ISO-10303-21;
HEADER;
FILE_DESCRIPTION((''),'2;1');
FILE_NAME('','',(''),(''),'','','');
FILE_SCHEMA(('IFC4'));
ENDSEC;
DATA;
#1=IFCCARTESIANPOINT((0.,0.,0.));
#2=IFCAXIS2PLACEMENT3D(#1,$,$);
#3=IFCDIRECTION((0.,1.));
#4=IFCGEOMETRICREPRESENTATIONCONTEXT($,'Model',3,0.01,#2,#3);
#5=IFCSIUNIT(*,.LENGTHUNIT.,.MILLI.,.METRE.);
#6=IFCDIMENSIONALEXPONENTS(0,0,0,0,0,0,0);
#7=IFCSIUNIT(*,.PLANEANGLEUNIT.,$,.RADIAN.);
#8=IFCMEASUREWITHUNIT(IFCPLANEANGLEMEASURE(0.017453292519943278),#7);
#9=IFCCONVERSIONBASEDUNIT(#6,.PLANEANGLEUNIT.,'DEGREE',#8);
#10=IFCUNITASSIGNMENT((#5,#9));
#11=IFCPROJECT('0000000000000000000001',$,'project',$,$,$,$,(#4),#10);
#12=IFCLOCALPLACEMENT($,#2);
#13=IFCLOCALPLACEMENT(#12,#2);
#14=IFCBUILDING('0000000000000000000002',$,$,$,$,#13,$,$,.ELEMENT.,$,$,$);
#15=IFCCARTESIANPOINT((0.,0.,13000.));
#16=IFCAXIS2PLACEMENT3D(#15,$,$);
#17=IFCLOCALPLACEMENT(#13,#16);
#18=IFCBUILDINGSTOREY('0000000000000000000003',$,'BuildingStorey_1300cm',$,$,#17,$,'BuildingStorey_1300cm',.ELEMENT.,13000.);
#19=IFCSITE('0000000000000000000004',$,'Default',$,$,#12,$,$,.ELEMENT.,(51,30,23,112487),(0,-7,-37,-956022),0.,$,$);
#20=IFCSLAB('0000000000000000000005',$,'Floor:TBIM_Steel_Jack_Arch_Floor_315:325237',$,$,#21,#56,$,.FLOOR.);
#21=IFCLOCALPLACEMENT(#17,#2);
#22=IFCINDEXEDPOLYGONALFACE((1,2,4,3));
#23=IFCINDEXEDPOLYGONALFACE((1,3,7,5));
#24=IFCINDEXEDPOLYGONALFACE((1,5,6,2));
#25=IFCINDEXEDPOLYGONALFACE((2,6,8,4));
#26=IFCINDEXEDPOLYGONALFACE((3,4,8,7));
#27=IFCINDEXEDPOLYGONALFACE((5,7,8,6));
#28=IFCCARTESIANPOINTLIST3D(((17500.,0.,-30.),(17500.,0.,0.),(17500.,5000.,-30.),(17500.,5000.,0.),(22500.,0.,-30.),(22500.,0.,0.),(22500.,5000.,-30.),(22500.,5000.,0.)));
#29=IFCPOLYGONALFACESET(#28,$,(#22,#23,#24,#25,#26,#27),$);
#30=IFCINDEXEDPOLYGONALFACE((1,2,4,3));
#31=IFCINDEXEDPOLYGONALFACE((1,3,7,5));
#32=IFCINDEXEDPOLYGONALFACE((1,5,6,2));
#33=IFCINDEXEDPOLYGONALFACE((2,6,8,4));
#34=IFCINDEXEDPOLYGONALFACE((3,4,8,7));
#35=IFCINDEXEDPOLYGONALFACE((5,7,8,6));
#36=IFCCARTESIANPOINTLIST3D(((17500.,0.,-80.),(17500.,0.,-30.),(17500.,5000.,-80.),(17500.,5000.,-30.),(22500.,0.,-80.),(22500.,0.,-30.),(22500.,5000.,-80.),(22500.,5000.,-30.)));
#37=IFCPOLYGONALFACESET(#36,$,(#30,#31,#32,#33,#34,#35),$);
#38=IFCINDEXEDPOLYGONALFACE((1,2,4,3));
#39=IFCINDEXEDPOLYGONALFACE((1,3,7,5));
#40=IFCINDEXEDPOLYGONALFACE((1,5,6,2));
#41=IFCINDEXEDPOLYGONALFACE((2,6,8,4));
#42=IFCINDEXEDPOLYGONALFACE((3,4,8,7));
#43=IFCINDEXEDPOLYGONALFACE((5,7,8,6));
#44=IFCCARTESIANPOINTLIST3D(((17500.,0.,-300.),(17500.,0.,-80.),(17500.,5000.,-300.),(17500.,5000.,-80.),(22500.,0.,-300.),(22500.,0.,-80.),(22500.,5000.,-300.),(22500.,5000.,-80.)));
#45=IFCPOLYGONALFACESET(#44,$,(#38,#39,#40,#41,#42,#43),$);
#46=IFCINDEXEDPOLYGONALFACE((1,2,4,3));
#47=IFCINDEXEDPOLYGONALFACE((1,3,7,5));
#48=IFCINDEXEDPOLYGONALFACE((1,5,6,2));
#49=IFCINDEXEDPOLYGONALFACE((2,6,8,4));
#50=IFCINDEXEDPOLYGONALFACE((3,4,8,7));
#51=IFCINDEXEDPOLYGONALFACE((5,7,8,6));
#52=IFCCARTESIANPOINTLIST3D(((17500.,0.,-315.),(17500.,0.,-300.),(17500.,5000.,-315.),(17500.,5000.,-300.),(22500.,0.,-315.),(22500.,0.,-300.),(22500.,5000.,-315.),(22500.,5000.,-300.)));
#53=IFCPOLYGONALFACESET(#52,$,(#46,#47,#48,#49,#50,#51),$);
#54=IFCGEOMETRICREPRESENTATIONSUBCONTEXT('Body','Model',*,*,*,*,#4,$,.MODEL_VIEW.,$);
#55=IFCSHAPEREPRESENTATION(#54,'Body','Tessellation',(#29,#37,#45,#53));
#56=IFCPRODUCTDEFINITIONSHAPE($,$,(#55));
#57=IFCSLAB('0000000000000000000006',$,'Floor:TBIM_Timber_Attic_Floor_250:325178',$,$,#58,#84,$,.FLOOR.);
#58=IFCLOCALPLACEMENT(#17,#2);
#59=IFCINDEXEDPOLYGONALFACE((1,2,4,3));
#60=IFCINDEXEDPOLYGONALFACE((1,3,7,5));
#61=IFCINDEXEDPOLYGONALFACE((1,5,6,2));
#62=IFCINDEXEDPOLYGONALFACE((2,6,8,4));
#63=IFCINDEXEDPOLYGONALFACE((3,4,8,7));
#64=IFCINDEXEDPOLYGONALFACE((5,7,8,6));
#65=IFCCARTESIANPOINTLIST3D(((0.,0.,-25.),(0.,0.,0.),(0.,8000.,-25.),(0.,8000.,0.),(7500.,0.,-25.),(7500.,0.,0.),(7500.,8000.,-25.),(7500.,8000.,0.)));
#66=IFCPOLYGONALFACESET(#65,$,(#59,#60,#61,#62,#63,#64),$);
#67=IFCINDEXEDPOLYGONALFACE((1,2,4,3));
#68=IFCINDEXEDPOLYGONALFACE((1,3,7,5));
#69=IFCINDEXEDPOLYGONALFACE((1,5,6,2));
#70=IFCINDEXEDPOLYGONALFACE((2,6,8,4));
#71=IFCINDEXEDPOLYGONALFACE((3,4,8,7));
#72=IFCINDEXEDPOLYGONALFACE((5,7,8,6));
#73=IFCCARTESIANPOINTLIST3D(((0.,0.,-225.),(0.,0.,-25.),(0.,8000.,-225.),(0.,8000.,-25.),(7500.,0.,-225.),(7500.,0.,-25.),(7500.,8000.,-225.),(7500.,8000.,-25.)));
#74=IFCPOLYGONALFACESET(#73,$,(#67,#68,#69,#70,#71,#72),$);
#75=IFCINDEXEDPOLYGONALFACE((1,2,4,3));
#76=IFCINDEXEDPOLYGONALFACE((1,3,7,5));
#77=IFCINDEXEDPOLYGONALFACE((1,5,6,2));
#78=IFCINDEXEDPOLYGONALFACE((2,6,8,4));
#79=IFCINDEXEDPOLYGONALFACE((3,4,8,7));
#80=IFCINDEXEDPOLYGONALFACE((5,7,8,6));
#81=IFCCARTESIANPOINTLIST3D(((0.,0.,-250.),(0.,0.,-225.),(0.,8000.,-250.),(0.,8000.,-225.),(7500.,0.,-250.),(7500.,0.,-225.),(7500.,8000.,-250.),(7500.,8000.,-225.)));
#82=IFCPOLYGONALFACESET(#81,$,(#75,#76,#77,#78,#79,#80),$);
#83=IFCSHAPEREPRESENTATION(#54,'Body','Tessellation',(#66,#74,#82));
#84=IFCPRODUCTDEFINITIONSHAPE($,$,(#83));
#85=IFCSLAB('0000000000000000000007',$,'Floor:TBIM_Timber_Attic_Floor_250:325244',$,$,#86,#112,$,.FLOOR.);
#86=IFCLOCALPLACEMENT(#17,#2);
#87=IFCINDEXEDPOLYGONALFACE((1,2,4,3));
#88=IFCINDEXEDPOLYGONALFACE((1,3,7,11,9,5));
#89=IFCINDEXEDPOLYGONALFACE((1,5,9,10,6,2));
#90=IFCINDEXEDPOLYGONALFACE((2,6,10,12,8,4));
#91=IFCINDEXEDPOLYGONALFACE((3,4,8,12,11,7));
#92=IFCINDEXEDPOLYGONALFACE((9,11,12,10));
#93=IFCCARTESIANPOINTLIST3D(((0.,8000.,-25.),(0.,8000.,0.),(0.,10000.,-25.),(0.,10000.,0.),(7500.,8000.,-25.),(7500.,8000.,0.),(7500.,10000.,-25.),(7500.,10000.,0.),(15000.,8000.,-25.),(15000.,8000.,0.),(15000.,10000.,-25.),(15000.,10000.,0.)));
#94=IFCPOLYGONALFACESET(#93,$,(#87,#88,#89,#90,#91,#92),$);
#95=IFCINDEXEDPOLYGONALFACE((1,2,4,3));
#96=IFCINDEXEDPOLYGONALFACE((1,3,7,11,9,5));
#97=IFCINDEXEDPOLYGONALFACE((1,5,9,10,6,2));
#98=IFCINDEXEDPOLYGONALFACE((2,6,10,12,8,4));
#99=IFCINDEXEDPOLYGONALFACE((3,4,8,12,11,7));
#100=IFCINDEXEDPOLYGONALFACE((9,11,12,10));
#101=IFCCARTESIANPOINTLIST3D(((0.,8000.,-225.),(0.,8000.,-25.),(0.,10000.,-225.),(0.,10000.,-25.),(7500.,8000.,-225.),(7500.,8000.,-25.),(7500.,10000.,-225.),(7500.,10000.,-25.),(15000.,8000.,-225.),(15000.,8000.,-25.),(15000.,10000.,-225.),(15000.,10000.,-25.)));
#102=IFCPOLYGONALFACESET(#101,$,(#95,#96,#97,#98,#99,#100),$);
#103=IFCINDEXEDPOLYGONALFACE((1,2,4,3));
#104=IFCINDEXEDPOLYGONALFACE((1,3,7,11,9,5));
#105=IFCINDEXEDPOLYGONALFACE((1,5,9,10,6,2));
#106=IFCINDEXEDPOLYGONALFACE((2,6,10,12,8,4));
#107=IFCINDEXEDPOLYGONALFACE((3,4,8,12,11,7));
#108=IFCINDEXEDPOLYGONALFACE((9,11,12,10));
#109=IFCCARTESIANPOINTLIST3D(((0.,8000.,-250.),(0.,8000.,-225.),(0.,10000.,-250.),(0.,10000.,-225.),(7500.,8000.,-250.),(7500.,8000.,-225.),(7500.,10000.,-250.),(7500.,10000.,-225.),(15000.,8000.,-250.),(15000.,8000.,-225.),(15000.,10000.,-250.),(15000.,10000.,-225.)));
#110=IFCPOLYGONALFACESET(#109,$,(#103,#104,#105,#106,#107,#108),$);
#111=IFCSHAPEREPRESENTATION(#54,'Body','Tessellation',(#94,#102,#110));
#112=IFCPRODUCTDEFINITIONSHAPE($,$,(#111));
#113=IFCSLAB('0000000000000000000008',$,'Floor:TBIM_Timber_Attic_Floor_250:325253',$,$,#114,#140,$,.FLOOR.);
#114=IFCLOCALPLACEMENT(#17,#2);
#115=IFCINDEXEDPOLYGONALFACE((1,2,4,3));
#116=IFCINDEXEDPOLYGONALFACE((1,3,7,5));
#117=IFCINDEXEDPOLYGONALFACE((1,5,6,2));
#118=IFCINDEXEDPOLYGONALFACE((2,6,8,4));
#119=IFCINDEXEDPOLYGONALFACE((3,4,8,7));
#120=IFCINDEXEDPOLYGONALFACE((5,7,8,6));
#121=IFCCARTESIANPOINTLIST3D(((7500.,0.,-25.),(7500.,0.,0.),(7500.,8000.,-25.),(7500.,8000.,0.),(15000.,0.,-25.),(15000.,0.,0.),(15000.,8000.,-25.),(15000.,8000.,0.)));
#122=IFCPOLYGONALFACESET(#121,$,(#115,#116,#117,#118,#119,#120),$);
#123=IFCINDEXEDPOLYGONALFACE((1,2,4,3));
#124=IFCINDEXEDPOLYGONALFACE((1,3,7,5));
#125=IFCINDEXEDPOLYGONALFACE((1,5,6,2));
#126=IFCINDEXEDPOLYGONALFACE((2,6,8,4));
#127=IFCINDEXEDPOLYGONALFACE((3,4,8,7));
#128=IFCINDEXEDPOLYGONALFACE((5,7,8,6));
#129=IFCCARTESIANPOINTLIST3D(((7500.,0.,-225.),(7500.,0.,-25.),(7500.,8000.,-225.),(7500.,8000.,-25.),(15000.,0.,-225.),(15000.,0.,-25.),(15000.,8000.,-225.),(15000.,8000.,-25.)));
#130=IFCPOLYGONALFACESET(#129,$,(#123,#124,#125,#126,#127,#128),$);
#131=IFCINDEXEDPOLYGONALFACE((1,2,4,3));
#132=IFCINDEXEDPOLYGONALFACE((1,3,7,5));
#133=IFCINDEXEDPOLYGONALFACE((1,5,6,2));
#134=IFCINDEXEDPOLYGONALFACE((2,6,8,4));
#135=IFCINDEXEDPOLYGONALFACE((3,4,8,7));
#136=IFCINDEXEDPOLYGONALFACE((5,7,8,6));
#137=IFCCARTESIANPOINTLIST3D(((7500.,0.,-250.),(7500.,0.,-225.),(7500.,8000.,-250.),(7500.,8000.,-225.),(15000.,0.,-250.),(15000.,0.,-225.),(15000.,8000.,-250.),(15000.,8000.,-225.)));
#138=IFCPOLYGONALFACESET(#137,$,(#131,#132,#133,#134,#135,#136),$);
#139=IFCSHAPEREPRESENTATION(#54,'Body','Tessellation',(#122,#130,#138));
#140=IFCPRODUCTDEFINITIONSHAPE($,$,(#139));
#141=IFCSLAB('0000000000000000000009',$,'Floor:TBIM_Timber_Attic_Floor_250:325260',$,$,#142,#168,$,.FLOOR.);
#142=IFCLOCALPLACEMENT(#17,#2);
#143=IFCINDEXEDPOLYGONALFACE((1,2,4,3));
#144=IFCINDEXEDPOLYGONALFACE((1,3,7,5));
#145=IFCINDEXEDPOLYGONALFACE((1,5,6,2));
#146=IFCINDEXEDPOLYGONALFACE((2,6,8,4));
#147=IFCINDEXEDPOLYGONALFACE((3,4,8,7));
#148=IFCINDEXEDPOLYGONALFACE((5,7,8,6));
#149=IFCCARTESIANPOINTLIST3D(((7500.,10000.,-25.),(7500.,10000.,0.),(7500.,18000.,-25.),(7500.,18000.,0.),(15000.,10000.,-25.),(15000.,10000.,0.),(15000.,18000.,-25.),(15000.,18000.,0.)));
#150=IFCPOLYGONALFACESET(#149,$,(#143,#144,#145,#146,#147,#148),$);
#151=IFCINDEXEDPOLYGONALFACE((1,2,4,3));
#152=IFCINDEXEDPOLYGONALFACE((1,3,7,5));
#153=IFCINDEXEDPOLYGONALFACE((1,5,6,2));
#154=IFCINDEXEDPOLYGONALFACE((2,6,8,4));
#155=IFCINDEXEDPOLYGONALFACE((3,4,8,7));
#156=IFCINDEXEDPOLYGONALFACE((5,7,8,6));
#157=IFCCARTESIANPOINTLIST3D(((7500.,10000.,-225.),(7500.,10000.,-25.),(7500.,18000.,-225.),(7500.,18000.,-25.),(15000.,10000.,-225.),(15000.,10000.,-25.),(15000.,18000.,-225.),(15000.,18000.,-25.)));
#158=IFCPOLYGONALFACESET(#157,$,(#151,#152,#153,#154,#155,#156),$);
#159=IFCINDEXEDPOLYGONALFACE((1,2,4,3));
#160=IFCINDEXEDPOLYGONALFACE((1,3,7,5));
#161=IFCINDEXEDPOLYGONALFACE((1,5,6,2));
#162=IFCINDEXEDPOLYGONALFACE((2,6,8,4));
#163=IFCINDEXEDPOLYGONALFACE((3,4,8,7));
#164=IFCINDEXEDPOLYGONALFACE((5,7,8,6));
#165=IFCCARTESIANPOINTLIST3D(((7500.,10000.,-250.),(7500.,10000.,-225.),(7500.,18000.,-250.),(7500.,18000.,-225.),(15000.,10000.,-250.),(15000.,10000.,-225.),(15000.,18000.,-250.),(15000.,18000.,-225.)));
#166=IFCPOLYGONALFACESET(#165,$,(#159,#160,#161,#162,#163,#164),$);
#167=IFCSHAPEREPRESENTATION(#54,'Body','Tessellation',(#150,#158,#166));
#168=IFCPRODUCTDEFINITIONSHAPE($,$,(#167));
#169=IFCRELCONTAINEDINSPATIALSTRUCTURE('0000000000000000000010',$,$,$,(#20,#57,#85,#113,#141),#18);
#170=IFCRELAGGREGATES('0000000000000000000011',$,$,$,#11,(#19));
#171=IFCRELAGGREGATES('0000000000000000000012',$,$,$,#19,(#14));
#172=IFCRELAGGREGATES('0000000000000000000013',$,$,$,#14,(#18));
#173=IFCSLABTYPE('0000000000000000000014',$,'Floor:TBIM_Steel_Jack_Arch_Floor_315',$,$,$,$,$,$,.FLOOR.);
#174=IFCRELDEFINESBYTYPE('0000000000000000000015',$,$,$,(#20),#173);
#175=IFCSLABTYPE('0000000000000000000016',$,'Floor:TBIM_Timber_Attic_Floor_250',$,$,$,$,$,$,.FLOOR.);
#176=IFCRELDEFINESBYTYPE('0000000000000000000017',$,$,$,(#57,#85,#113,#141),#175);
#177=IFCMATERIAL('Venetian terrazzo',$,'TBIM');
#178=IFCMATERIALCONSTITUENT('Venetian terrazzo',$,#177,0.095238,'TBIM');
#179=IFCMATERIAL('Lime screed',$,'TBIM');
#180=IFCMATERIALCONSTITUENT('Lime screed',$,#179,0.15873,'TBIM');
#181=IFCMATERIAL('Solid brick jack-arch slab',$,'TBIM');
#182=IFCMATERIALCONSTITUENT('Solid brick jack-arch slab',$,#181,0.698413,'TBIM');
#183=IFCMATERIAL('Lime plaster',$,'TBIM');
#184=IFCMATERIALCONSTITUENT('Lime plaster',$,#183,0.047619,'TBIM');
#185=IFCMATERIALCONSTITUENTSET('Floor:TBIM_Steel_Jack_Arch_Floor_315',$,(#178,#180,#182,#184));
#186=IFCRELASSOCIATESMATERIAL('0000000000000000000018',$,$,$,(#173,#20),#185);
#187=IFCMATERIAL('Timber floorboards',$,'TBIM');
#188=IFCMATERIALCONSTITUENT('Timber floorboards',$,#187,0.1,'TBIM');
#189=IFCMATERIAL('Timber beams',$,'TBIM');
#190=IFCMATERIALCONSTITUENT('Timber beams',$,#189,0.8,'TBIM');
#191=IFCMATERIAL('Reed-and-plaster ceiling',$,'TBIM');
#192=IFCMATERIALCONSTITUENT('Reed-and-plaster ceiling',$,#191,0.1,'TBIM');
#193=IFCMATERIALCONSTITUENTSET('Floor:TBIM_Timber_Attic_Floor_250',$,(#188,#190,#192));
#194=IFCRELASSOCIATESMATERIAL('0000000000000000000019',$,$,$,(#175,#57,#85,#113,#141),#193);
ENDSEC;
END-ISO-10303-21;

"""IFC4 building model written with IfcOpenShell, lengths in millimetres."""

from ifc_helpers import new_model, entity, si_unit, converted_unit, direction, frame, origin, place, context, subcontext, project, spatial, indexed_curve, outline, extrude, material, constituent, constituent_set, type_object, element, save


model = new_model("IFC4")

# Units and contexts
model_context = context("Model", 3, precision=0.01, world=origin(), true_north=direction((0.0, 1.0)))
body_context = subcontext(model_context, "Body", "Model", "MODEL_VIEW")
ifc_project = project(units=[si_unit("LENGTHUNIT", "METRE", prefix="MILLI"), converted_unit("PLANEANGLEUNIT", "DEGREE", entity("IfcPlaneAngleMeasure", 0.017453292519943278), si_unit("PLANEANGLEUNIT", "RADIAN"), dimensions=[0, 0, 0, 0, 0, 0, 0])], contexts=[model_context])

# Site, building, storey
site_placement = place(None, origin())
site = spatial("IfcSite", under=ifc_project, at=site_placement, Name="Default", CompositionType="ELEMENT", RefLatitude=(51, 30, 23, 112487), RefLongitude=(0, -7, -37, -956022), RefElevation=0.0)
building_placement = place(site_placement, origin())
building = spatial("IfcBuilding", under=site, at=building_placement, CompositionType="ELEMENT")
storey_placement = place(building_placement, frame((0.0, 0.0, 13000.0)))
storey = spatial("IfcBuildingStorey", under=building, at=storey_placement, Name="BuildingStorey_1300cm", LongName="BuildingStorey_1300cm", CompositionType="ELEMENT", Elevation=13000.0)

# Slabs
ifc_material_1 = material(Name="Venetian terrazzo", Category="TBIM")
ifc_constituent_1 = constituent(ifc_material_1, Name="Venetian terrazzo", Category="TBIM", fraction=0.095238)
ifc_material_2 = material(Name="Lime screed", Category="TBIM")
ifc_constituent_2 = constituent(ifc_material_2, Name="Lime screed", Category="TBIM", fraction=0.15873)
ifc_material_3 = material(Name="Solid brick jack-arch slab", Category="TBIM")
ifc_constituent_3 = constituent(ifc_material_3, Name="Solid brick jack-arch slab", Category="TBIM", fraction=0.698413)
ifc_material_4 = material(Name="Lime plaster", Category="TBIM")
ifc_constituent_4 = constituent(ifc_material_4, Name="Lime plaster", Category="TBIM", fraction=0.047619)
ifc_constituent_set_1 = constituent_set(constituents=[ifc_constituent_1, ifc_constituent_2, ifc_constituent_3, ifc_constituent_4], Name="Floor:TBIM_Steel_Jack_Arch_Floor_315")
slab_type_1 = type_object("IfcSlabType", Name="Floor:TBIM_Steel_Jack_Arch_Floor_315", PredefinedType="FLOOR", material=ifc_constituent_set_1)
slab_1_placement = place(storey_placement, origin())
element("IfcSlab", 1, at=slab_1_placement, inside=storey, type_object=slab_type_1, material=ifc_constituent_set_1, Name="Floor:TBIM_Steel_Jack_Arch_Floor_315:325237", PredefinedType="FLOOR", context=body_context, shape_type="SweptSolid", body=[
    extrude(outline(indexed_curve([(-2500.0, -2500.0), (2500.0, -2500.0), (2500.0, 2500.0), (-2500.0, 2500.0), (-2500.0, -2500.0)], self_intersect=False)), frame((20000.0, 2500.0, -30.0)), (0.0, 0.0, 1.0), 30.0),
    extrude(outline(indexed_curve([(-2500.0, -2500.0), (2500.0, -2500.0), (2500.0, 2500.0), (-2500.0, 2500.0), (-2500.0, -2500.0)], self_intersect=False)), frame((20000.0, 2500.0, -80.0)), (0.0, 0.0, 1.0), 50.0),
    extrude(outline(indexed_curve([(-2500.0, -2500.0), (2500.0, -2500.0), (2500.0, 2500.0), (-2500.0, 2500.0), (-2500.0, -2500.0)], self_intersect=False)), frame((20000.0, 2500.0, -300.0)), (0.0, 0.0, 1.0), 220.0),
    extrude(outline(indexed_curve([(-2500.0, -2500.0), (2500.0, -2500.0), (2500.0, 2500.0), (-2500.0, 2500.0), (-2500.0, -2500.0)], self_intersect=False)), frame((20000.0, 2500.0, -315.0)), (0.0, 0.0, 1.0), 15.0),
])
ifc_material_5 = material(Name="Timber floorboards", Category="TBIM")
ifc_constituent_5 = constituent(ifc_material_5, Name="Timber floorboards", Category="TBIM", fraction=0.1)
ifc_material_6 = material(Name="Timber beams", Category="TBIM")
ifc_constituent_6 = constituent(ifc_material_6, Name="Timber beams", Category="TBIM", fraction=0.8)
ifc_material_7 = material(Name="Reed-and-plaster ceiling", Category="TBIM")
ifc_constituent_7 = constituent(ifc_material_7, Name="Reed-and-plaster ceiling", Category="TBIM", fraction=0.1)
ifc_constituent_set_2 = constituent_set(constituents=[ifc_constituent_5, ifc_constituent_6, ifc_constituent_7], Name="Floor:TBIM_Timber_Attic_Floor_250")
slab_type_2 = type_object("IfcSlabType", Name="Floor:TBIM_Timber_Attic_Floor_250", PredefinedType="FLOOR", material=ifc_constituent_set_2)
slab_2_placement = place(storey_placement, origin())
element("IfcSlab", 2, at=slab_2_placement, inside=storey, type_object=slab_type_2, material=ifc_constituent_set_2, Name="Floor:TBIM_Timber_Attic_Floor_250:325178", PredefinedType="FLOOR", context=body_context, shape_type="SweptSolid", body=[
    extrude(outline(indexed_curve([(-3750.0, -4000.0), (3750.0, -4000.0), (3750.0, 4000.0), (-3750.0, 4000.0), (-3750.0, -4000.0)], self_intersect=False)), frame((3750.0, 4000.0, -25.0), z_axis=(0.0, 0.0, 1.0), x_axis=(-1.0, 0.0, 0.0)), (0.0, 0.0, 1.0), 25.0),
    extrude(outline(indexed_curve([(-3750.0, -4000.0), (3750.0, -4000.0), (3750.0, 4000.0), (-3750.0, 4000.0), (-3750.0, -4000.0)], self_intersect=False)), frame((3750.0, 4000.0, -225.0), z_axis=(0.0, 0.0, 1.0), x_axis=(-1.0, 0.0, 0.0)), (0.0, 0.0, 1.0), 200.0),
    extrude(outline(indexed_curve([(-3750.0, -4000.0), (3750.0, -4000.0), (3750.0, 4000.0), (-3750.0, 4000.0), (-3750.0, -4000.0)], self_intersect=False)), frame((3750.0, 4000.0, -250.0), z_axis=(0.0, 0.0, 1.0), x_axis=(-1.0, 0.0, 0.0)), (0.0, 0.0, 1.0), 25.0),
])
slab_3_placement = place(storey_placement, origin())
element("IfcSlab", 3, at=slab_3_placement, inside=storey, type_object=slab_type_2, material=ifc_constituent_set_2, Name="Floor:TBIM_Timber_Attic_Floor_250:325244", PredefinedType="FLOOR", context=body_context, shape_type="SweptSolid", body=[
    extrude(outline(indexed_curve([(-7500.0, -1000.0), (0.0, -1000.0), (7500.0, -1000.0), (7500.0, 1000.0), (0.0, 1000.0), (-7500.0, 1000.0), (-7500.0, -1000.0)], self_intersect=False)), frame((7500.0, 9000.0, -25.0), z_axis=(0.0, 0.0, 1.0), x_axis=(-1.0, 0.0, 0.0)), (0.0, 0.0, 1.0), 25.0),
    extrude(outline(indexed_curve([(-7500.0, -1000.0), (0.0, -1000.0), (7500.0, -1000.0), (7500.0, 1000.0), (0.0, 1000.0), (-7500.0, 1000.0), (-7500.0, -1000.0)], self_intersect=False)), frame((7500.0, 9000.0, -225.0), z_axis=(0.0, 0.0, 1.0), x_axis=(-1.0, 0.0, 0.0)), (0.0, 0.0, 1.0), 200.0),
    extrude(outline(indexed_curve([(-7500.0, -1000.0), (0.0, -1000.0), (7500.0, -1000.0), (7500.0, 1000.0), (0.0, 1000.0), (-7500.0, 1000.0), (-7500.0, -1000.0)], self_intersect=False)), frame((7500.0, 9000.0, -250.0), z_axis=(0.0, 0.0, 1.0), x_axis=(-1.0, 0.0, 0.0)), (0.0, 0.0, 1.0), 25.0),
])
slab_4_placement = place(storey_placement, origin())
element("IfcSlab", 4, at=slab_4_placement, inside=storey, type_object=slab_type_2, material=ifc_constituent_set_2, Name="Floor:TBIM_Timber_Attic_Floor_250:325253", PredefinedType="FLOOR", context=body_context, shape_type="SweptSolid", body=[
    extrude(outline(indexed_curve([(-3750.0, -4000.0), (3750.0, -4000.0), (3750.0, 4000.0), (-3750.0, 4000.0), (-3750.0, -4000.0)], self_intersect=False)), frame((11250.0, 4000.0, -25.0), z_axis=(0.0, 0.0, 1.0), x_axis=(-1.0, 0.0, 0.0)), (0.0, 0.0, 1.0), 25.0),
    extrude(outline(indexed_curve([(-3750.0, -4000.0), (3750.0, -4000.0), (3750.0, 4000.0), (-3750.0, 4000.0), (-3750.0, -4000.0)], self_intersect=False)), frame((11250.0, 4000.0, -225.0), z_axis=(0.0, 0.0, 1.0), x_axis=(-1.0, 0.0, 0.0)), (0.0, 0.0, 1.0), 200.0),
    extrude(outline(indexed_curve([(-3750.0, -4000.0), (3750.0, -4000.0), (3750.0, 4000.0), (-3750.0, 4000.0), (-3750.0, -4000.0)], self_intersect=False)), frame((11250.0, 4000.0, -250.0), z_axis=(0.0, 0.0, 1.0), x_axis=(-1.0, 0.0, 0.0)), (0.0, 0.0, 1.0), 25.0),
])
slab_5_placement = place(storey_placement, origin())
element("IfcSlab", 5, at=slab_5_placement, inside=storey, type_object=slab_type_2, material=ifc_constituent_set_2, Name="Floor:TBIM_Timber_Attic_Floor_250:325260", PredefinedType="FLOOR", context=body_context, shape_type="SweptSolid", body=[
    extrude(outline(indexed_curve([(-3750.0, -4000.0), (3750.0, -4000.0), (3750.0, 4000.0), (-3750.0, 4000.0), (-3750.0, -4000.0)], self_intersect=False)), frame((11250.0, 14000.0, -25.0), z_axis=(0.0, 0.0, 1.0), x_axis=(-1.0, 0.0, 0.0)), (0.0, 0.0, 1.0), 25.0),
    extrude(outline(indexed_curve([(-3750.0, -4000.0), (3750.0, -4000.0), (3750.0, 4000.0), (-3750.0, 4000.0), (-3750.0, -4000.0)], self_intersect=False)), frame((11250.0, 14000.0, -225.0), z_axis=(0.0, 0.0, 1.0), x_axis=(-1.0, 0.0, 0.0)), (0.0, 0.0, 1.0), 200.0),
    extrude(outline(indexed_curve([(-3750.0, -4000.0), (3750.0, -4000.0), (3750.0, 4000.0), (-3750.0, 4000.0), (-3750.0, -4000.0)], self_intersect=False)), frame((11250.0, 14000.0, -250.0), z_axis=(0.0, 0.0, 1.0), x_axis=(-1.0, 0.0, 0.0)), (0.0, 0.0, 1.0), 25.0),
])

save(model, "model.ifc")
